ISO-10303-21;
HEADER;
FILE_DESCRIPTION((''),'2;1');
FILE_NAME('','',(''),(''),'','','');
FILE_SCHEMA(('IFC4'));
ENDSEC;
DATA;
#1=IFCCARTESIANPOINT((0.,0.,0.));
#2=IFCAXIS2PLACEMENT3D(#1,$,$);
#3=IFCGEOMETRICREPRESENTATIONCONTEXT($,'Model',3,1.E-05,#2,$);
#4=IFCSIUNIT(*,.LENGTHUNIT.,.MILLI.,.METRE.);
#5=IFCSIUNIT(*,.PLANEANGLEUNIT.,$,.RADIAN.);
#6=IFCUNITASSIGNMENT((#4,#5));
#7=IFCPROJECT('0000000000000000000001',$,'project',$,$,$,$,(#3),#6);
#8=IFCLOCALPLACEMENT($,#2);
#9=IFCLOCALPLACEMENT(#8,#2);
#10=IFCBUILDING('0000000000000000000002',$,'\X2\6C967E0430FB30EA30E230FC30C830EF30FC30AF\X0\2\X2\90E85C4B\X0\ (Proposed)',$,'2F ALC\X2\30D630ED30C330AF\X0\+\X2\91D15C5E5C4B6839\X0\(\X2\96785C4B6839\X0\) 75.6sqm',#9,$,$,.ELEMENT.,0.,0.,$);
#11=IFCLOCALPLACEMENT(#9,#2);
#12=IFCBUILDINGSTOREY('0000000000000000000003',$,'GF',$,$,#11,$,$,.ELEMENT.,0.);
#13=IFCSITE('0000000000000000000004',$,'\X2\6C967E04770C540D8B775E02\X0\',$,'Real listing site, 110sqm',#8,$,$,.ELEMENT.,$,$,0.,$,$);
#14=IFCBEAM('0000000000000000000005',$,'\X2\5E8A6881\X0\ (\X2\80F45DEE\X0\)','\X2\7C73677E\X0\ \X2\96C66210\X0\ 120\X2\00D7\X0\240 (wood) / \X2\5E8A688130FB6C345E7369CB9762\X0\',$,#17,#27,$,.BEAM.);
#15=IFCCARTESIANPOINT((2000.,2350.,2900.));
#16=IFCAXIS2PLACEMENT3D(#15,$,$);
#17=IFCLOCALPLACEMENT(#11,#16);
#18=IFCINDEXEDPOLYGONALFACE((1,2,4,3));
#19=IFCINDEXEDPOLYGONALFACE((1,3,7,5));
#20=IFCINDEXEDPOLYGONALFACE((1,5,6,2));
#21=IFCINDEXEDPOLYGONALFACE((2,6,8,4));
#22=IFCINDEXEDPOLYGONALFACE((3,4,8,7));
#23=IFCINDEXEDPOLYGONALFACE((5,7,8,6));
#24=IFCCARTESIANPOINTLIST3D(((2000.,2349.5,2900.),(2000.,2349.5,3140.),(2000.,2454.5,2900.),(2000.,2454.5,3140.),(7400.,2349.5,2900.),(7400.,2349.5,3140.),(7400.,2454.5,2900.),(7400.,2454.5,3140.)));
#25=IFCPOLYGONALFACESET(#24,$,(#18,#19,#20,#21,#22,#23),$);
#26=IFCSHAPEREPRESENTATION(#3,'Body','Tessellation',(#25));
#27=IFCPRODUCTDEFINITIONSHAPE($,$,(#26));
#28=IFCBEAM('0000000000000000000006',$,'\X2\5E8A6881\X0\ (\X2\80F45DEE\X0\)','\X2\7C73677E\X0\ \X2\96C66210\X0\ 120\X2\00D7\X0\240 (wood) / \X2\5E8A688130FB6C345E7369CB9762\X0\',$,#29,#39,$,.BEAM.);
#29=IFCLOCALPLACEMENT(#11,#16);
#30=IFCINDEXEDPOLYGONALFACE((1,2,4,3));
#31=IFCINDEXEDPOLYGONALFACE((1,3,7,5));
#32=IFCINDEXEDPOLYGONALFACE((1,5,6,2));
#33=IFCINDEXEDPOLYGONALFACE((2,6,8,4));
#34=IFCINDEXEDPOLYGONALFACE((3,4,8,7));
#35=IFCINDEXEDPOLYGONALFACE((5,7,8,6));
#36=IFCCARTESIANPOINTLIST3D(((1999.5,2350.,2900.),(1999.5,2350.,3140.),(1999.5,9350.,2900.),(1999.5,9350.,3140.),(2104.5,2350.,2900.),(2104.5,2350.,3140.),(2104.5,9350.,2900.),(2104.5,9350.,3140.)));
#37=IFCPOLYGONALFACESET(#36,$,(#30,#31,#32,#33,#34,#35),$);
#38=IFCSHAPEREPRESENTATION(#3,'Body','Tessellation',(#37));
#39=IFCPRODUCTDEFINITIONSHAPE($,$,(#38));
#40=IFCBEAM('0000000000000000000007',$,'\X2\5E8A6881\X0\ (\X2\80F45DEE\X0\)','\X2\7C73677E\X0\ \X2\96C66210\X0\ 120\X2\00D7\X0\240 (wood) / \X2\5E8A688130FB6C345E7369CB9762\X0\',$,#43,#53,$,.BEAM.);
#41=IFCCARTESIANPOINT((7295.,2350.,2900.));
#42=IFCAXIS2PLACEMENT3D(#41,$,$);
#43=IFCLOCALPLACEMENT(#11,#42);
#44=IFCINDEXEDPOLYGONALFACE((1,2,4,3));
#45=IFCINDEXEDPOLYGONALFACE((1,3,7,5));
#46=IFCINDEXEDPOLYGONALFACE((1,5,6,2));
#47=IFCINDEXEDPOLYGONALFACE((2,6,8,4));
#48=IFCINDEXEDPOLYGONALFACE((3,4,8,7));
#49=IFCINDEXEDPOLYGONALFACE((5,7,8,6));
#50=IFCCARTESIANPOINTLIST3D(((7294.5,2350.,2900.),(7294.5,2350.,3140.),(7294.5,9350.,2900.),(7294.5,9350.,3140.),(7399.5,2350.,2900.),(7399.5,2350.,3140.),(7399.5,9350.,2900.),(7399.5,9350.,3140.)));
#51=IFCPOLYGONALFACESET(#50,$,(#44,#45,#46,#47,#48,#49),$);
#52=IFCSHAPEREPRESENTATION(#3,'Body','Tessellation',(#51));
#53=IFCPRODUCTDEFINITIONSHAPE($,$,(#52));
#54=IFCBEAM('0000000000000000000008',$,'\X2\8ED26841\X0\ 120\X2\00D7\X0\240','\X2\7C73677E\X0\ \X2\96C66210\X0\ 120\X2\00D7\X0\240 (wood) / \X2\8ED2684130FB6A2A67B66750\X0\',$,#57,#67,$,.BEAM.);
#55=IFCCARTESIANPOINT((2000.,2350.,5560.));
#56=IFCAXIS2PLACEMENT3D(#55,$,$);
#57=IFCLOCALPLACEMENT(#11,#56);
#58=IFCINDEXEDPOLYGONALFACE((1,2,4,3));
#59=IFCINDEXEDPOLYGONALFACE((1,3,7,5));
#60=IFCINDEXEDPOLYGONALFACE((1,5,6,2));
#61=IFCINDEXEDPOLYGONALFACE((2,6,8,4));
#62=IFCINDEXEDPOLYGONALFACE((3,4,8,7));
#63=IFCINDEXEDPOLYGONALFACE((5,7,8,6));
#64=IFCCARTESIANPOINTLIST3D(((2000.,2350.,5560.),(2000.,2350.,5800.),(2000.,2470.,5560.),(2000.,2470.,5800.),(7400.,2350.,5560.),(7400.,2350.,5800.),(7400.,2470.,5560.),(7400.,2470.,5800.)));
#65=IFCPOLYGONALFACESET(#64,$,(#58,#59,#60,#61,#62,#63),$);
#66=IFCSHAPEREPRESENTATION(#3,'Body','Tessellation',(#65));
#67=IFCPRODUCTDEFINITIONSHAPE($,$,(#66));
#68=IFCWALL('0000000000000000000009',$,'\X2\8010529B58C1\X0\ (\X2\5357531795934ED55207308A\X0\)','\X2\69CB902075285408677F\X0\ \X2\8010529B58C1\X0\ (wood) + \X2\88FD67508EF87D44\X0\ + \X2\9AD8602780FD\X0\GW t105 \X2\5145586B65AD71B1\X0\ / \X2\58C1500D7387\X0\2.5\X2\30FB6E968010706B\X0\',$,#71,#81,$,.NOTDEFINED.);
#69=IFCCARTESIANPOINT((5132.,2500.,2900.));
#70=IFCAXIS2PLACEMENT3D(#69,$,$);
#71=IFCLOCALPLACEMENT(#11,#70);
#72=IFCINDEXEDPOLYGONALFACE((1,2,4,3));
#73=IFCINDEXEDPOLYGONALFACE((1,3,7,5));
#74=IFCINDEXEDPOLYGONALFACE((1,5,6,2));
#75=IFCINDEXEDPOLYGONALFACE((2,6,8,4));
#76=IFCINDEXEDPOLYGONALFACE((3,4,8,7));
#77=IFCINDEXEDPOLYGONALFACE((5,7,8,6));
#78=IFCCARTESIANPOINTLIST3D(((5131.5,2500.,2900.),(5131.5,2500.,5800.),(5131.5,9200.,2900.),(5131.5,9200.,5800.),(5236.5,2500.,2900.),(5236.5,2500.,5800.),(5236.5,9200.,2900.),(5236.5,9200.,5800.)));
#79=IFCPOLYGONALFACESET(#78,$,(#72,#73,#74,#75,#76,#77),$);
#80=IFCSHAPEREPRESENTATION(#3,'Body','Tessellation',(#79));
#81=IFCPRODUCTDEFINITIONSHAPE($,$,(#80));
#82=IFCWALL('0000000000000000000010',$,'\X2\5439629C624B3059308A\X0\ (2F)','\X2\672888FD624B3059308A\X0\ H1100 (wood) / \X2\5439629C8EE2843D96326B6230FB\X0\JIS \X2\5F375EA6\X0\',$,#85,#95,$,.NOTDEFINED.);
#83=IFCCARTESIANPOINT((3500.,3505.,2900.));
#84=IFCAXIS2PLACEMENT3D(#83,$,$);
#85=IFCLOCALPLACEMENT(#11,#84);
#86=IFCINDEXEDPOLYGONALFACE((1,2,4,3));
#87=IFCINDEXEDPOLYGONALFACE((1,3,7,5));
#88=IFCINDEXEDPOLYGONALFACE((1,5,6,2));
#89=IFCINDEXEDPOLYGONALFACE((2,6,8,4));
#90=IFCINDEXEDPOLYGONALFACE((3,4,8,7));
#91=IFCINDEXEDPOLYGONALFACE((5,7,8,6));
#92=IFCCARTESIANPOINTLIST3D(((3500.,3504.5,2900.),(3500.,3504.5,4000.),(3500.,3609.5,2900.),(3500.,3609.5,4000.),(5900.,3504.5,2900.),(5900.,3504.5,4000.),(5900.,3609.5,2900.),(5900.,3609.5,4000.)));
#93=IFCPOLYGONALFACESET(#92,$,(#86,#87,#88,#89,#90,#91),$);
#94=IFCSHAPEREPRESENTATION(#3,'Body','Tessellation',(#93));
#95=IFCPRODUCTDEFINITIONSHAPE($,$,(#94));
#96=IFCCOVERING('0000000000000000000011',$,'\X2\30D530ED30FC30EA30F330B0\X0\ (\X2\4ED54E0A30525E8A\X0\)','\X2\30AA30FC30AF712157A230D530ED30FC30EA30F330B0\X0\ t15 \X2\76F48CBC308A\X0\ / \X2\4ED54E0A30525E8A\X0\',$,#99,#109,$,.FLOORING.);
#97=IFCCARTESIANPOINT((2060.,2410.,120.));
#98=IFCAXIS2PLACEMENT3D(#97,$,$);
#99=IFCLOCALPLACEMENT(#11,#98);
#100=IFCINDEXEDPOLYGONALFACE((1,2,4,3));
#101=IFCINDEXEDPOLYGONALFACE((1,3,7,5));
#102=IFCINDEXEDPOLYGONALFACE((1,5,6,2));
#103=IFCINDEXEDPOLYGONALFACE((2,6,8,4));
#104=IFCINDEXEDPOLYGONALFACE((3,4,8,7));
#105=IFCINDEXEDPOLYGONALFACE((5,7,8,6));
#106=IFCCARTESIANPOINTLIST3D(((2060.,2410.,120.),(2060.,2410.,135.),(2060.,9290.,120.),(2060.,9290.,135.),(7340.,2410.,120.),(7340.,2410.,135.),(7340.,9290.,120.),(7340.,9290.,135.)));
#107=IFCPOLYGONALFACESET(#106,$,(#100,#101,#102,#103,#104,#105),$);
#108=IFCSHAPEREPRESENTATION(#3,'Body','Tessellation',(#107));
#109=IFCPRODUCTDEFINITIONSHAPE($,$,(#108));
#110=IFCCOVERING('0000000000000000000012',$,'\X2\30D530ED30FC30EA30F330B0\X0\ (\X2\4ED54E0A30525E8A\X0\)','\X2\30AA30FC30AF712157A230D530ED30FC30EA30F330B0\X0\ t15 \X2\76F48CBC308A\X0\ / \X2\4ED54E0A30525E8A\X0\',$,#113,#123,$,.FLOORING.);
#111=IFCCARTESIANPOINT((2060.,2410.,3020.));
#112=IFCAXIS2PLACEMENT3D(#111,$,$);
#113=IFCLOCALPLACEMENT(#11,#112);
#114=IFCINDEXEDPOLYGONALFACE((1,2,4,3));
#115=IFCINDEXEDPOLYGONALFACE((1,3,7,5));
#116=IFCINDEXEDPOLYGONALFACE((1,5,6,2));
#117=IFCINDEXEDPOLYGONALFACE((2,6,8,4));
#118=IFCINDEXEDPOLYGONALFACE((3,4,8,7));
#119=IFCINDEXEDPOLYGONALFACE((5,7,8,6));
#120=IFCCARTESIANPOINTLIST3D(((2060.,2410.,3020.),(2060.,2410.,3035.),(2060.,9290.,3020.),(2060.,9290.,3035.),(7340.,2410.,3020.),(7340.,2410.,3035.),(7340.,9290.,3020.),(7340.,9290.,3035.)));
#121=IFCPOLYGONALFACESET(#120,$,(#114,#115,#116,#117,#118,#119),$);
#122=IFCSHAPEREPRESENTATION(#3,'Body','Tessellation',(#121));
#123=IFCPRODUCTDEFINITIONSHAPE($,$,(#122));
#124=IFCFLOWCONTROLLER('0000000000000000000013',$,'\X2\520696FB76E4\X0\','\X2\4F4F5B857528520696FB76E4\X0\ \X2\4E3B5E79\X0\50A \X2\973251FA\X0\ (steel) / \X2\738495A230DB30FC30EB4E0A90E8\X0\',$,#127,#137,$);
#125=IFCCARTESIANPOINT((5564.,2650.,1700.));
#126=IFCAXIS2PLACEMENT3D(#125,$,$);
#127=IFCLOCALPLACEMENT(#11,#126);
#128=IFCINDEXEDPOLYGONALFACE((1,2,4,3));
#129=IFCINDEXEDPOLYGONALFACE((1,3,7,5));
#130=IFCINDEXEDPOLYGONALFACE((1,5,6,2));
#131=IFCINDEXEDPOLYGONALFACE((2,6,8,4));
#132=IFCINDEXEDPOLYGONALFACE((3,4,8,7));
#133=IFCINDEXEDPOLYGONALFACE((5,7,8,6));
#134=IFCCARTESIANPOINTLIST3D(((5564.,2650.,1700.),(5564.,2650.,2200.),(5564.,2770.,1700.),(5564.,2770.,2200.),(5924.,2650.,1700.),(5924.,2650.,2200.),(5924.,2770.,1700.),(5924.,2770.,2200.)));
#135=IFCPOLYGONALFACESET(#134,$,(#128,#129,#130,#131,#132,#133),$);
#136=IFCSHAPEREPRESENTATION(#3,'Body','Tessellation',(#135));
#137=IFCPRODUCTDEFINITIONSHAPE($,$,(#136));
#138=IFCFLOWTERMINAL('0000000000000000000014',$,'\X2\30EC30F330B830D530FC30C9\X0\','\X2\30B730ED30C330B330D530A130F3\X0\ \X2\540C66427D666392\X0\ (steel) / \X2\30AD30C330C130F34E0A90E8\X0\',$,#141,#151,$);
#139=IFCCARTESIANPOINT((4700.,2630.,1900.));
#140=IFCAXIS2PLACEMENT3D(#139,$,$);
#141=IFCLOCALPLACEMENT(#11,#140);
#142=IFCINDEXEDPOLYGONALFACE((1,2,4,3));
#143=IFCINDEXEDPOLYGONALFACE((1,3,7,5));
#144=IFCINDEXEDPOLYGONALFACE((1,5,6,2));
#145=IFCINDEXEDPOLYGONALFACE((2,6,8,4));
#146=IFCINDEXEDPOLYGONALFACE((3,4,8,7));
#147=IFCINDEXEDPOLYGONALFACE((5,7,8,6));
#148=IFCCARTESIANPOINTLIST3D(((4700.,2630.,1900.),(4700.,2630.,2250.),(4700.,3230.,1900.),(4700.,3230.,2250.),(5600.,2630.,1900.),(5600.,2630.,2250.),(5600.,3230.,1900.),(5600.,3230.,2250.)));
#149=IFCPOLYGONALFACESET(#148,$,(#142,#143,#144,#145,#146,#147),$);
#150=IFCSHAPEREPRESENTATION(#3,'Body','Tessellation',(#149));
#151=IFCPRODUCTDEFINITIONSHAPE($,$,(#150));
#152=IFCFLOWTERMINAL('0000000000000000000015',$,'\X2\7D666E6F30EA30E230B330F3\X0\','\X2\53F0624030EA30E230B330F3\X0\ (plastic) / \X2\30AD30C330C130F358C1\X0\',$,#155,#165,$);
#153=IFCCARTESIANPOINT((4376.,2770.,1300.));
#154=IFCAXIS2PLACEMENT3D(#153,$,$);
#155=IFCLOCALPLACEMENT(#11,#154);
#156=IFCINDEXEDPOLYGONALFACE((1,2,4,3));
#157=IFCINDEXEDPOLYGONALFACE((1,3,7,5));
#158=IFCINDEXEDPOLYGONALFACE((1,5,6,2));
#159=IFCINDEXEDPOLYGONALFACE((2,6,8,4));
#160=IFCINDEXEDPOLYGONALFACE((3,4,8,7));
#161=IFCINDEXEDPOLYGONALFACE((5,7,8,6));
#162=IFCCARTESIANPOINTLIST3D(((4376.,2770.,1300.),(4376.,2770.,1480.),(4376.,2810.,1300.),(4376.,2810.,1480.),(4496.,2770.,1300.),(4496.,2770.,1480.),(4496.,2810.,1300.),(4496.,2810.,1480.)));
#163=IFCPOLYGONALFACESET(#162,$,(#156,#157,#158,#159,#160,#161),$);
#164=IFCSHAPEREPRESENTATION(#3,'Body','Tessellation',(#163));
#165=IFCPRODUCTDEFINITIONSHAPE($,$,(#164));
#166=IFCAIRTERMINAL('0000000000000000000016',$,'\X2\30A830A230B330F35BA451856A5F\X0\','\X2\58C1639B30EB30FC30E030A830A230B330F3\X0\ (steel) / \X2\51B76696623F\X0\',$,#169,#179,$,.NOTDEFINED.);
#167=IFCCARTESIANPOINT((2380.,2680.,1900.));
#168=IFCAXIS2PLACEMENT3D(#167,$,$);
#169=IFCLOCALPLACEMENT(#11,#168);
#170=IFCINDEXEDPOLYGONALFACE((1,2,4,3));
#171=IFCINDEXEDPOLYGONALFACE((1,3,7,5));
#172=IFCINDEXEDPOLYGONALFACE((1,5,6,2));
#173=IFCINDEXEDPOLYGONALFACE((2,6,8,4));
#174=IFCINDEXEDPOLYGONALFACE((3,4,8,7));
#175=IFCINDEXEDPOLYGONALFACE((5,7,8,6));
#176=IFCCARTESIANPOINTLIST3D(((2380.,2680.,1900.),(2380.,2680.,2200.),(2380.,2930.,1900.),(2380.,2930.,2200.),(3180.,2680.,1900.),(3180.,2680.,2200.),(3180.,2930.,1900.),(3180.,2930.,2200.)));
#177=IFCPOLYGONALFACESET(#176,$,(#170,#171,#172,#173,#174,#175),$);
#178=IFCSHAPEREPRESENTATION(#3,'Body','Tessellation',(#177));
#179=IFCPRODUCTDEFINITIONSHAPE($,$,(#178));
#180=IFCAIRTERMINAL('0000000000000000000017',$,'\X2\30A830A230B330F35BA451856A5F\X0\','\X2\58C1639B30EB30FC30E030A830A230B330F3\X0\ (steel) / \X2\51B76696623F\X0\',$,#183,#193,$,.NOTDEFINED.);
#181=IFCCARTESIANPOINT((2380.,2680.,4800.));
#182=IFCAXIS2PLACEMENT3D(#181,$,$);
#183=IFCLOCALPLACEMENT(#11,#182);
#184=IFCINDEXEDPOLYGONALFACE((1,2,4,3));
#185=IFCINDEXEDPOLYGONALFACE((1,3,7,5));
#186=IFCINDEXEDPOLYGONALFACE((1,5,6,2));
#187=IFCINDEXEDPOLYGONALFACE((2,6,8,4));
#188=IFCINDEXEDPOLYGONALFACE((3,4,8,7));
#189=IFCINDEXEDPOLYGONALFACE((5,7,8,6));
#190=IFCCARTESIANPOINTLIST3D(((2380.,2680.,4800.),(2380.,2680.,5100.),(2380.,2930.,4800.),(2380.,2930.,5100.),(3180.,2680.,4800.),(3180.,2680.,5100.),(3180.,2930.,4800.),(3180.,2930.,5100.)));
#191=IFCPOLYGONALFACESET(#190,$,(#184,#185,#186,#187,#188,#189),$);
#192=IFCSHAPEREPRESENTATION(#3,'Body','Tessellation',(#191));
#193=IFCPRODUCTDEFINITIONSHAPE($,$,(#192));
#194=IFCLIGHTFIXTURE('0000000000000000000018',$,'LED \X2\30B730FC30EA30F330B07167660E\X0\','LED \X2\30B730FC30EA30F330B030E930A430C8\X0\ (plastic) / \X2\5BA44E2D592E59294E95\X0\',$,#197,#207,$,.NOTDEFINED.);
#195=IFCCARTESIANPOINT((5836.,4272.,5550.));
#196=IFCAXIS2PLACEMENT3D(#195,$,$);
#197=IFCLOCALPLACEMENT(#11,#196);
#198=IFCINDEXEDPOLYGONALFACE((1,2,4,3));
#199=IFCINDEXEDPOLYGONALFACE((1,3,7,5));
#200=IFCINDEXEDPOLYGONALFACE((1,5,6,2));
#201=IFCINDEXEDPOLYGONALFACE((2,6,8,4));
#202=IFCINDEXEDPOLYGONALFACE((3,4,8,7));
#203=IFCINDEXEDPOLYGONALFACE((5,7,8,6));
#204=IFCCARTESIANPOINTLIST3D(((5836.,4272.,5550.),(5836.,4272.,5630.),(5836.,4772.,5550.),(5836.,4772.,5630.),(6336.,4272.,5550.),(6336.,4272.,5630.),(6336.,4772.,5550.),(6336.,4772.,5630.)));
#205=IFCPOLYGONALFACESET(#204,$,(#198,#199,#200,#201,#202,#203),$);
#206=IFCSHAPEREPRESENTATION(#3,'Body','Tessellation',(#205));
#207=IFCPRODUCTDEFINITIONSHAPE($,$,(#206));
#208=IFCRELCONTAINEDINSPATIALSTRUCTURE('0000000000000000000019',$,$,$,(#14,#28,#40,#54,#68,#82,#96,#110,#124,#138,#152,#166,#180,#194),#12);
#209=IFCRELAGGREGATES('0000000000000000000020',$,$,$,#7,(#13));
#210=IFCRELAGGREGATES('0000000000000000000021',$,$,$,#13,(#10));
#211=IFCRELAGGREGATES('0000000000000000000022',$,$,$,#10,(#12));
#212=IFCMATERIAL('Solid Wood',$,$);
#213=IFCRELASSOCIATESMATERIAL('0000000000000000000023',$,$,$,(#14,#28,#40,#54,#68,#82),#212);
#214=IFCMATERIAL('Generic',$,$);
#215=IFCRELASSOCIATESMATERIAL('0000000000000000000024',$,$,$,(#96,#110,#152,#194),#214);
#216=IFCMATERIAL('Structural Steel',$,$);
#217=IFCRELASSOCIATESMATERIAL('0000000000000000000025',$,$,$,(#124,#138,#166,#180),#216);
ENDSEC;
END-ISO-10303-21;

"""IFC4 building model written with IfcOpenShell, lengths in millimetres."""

from ifc_helpers import new_model, si_unit, frame, frame_2d, origin, place, context, project, spatial, rectangle, extrude, material, element, save


model = new_model("IFC4")

# Units and contexts
model_context = context("Model", 3, precision=1e-05, world=origin())
ifc_project = project(units=[si_unit("LENGTHUNIT", "METRE", prefix="MILLI"), si_unit("PLANEANGLEUNIT", "RADIAN")], contexts=[model_context])

# Site, building, storey
site_placement = place(None, origin())
site = spatial("IfcSite", under=ifc_project, at=site_placement, Name="沖縄県名護市", ObjectType="Real listing site, 110sqm", CompositionType="ELEMENT", RefElevation=0.0)
building_placement = place(site_placement, origin())
building = spatial("IfcBuilding", under=site, at=building_placement, Name="沖縄・リモートワーク2部屋 (Proposed)", ObjectType="2F ALCブロック+金属屋根(陸屋根) 75.6sqm", CompositionType="ELEMENT", ElevationOfRefHeight=0.0, ElevationOfTerrain=0.0)
storey_placement = place(building_placement, origin())
storey = spatial("IfcBuildingStorey", under=building, at=storey_placement, Name="GF", CompositionType="ELEMENT", Elevation=0.0)

# Shared definitions
ifc_material_1 = material(Name="Solid Wood")

# Beams
beam_1_placement = place(storey_placement, frame((2000.0, 2350.0, 2900.0)))
element("IfcBeam", 1, at=beam_1_placement, inside=storey, material=ifc_material_1, Name="床梁 (胴差)", Description="米松 集成 120×240 (wood) / 床梁・水平構面", PredefinedType="BEAM", context=model_context, shape_type="SweptSolid", body=[
    extrude(rectangle(XDim=5400.0, YDim=105.0, at=frame_2d((2700.0, 52.0))), frame((2000.0, 2350.0, 2900.0)), (0.0, 0.0, 1.0), 240.0),
])
beam_2_placement = place(storey_placement, frame((2000.0, 2350.0, 2900.0)))
element("IfcBeam", 2, at=beam_2_placement, inside=storey, material=ifc_material_1, Name="床梁 (胴差)", Description="米松 集成 120×240 (wood) / 床梁・水平構面", PredefinedType="BEAM", context=model_context, shape_type="SweptSolid", body=[
    extrude(rectangle(XDim=105.0, YDim=7000.0, at=frame_2d((52.0, 3500.0))), frame((2000.0, 2350.0, 2900.0)), (0.0, 0.0, 1.0), 240.0),
])
beam_3_placement = place(storey_placement, frame((7295.0, 2350.0, 2900.0)))
element("IfcBeam", 3, at=beam_3_placement, inside=storey, material=ifc_material_1, Name="床梁 (胴差)", Description="米松 集成 120×240 (wood) / 床梁・水平構面", PredefinedType="BEAM", context=model_context, shape_type="SweptSolid", body=[
    extrude(rectangle(XDim=105.0, YDim=7000.0, at=frame_2d((52.0, 3500.0))), frame((7295.0, 2350.0, 2900.0)), (0.0, 0.0, 1.0), 240.0),
])
beam_4_placement = place(storey_placement, frame((2000.0, 2350.0, 5560.0)))
element("IfcBeam", 4, at=beam_4_placement, inside=storey, material=ifc_material_1, Name="軒桁 120×240", Description="米松 集成 120×240 (wood) / 軒桁・横架材", PredefinedType="BEAM", context=model_context, shape_type="SweptSolid", body=[
    extrude(rectangle(XDim=5400.0, YDim=120.0, at=frame_2d((2700.0, 60.0))), frame((2000.0, 2350.0, 5560.0)), (0.0, 0.0, 1.0), 240.0),
])

# Walls
wall_1_placement = place(storey_placement, frame((5132.0, 2500.0, 2900.0)))
element("IfcWall", 5, at=wall_1_placement, inside=storey, material=ifc_material_1, Name="耐力壁 (南北間仕切り)", Description="構造用合板 耐力壁 (wood) + 製材軸組 + 高性能GW t105 充填断熱 / 壁倍率2.5・準耐火", PredefinedType="NOTDEFINED", context=model_context, shape_type="SweptSolid", body=[
    extrude(rectangle(XDim=105.0, YDim=6700.0, at=frame_2d((52.0, 3350.0))), frame((5132.0, 2500.0, 2900.0)), (0.0, 0.0, 1.0), 2900.0),
])
wall_2_placement = place(storey_placement, frame((3500.0, 3505.0, 2900.0)))
element("IfcWall", 6, at=wall_2_placement, inside=storey, material=ifc_material_1, Name="吹抜手すり (2F)", Description="木製手すり H1100 (wood) / 吹抜転落防止・JIS 強度", PredefinedType="NOTDEFINED", context=model_context, shape_type="SweptSolid", body=[
    extrude(rectangle(XDim=2400.0, YDim=105.0, at=frame_2d((1200.0, 52.0))), frame((3500.0, 3505.0, 2900.0)), (0.0, 0.0, 1.0), 1100.0),
])

# Coverings
ifc_material_2 = material(Name="Generic")
covering_1_placement = place(storey_placement, frame((2060.0, 2410.0, 120.0)))
element("IfcCovering", 7, at=covering_1_placement, inside=storey, material=ifc_material_2, Name="フローリング (仕上げ床)", Description="オーク無垢フローリング t15 直貼り / 仕上げ床", PredefinedType="FLOORING", context=model_context, shape_type="SweptSolid", body=[
    extrude(rectangle(XDim=5280.0, YDim=6880.0, at=frame_2d((2640.0, 3440.0))), frame((2060.0, 2410.0, 120.0)), (0.0, 0.0, 1.0), 15.0),
])
covering_2_placement = place(storey_placement, frame((2060.0, 2410.0, 3020.0)))
element("IfcCovering", 8, at=covering_2_placement, inside=storey, material=ifc_material_2, Name="フローリング (仕上げ床)", Description="オーク無垢フローリング t15 直貼り / 仕上げ床", PredefinedType="FLOORING", context=model_context, shape_type="SweptSolid", body=[
    extrude(rectangle(XDim=5280.0, YDim=6880.0, at=frame_2d((2640.0, 3440.0))), frame((2060.0, 2410.0, 3020.0)), (0.0, 0.0, 1.0), 15.0),
])

# Flow controller
ifc_material_3 = material(Name="Structural Steel")
flow_controller_placement = place(storey_placement, frame((5564.0, 2650.0, 1700.0)))
element("IfcFlowController", 9, at=flow_controller_placement, inside=storey, material=ifc_material_3, Name="分電盤", Description="住宅用分電盤 主幹50A 露出 (steel) / 玄関ホール上部", context=model_context, shape_type="SweptSolid", body=[
    extrude(rectangle(XDim=360.0, YDim=120.0, at=frame_2d((180.0, 60.0))), frame((5564.0, 2650.0, 1700.0)), (0.0, 0.0, 1.0), 500.0),
])

# Flow terminals
flow_terminal_1_placement = place(storey_placement, frame((4700.0, 2630.0, 1900.0)))
element("IfcFlowTerminal", 10, at=flow_terminal_1_placement, inside=storey, material=ifc_material_3, Name="レンジフード", Description="シロッコファン 同時給排 (steel) / キッチン上部", context=model_context, shape_type="SweptSolid", body=[
    extrude(rectangle(XDim=900.0, YDim=600.0, at=frame_2d((450.0, 300.0))), frame((4700.0, 2630.0, 1900.0)), (0.0, 0.0, 1.0), 350.0),
])
flow_terminal_2_placement = place(storey_placement, frame((4376.0, 2770.0, 1300.0)))
element("IfcFlowTerminal", 11, at=flow_terminal_2_placement, inside=storey, material=ifc_material_2, Name="給湯リモコン", Description="台所リモコン (plastic) / キッチン壁", context=model_context, shape_type="SweptSolid", body=[
    extrude(rectangle(XDim=120.0, YDim=40.0, at=frame_2d((60.0, 20.0))), frame((4376.0, 2770.0, 1300.0)), (0.0, 0.0, 1.0), 180.0),
])

# Air terminals
air_terminal_1_placement = place(storey_placement, frame((2380.0, 2680.0, 1900.0)))
element("IfcAirTerminal", 12, at=air_terminal_1_placement, inside=storey, material=ifc_material_3, Name="エアコン室内機", Description="壁掛ルームエアコン (steel) / 冷暖房", PredefinedType="NOTDEFINED", context=model_context, shape_type="SweptSolid", body=[
    extrude(rectangle(XDim=800.0, YDim=250.0, at=frame_2d((400.0, 125.0))), frame((2380.0, 2680.0, 1900.0)), (0.0, 0.0, 1.0), 300.0),
])
air_terminal_2_placement = place(storey_placement, frame((2380.0, 2680.0, 4800.0)))
element("IfcAirTerminal", 13, at=air_terminal_2_placement, inside=storey, material=ifc_material_3, Name="エアコン室内機", Description="壁掛ルームエアコン (steel) / 冷暖房", PredefinedType="NOTDEFINED", context=model_context, shape_type="SweptSolid", body=[
    extrude(rectangle(XDim=800.0, YDim=250.0, at=frame_2d((400.0, 125.0))), frame((2380.0, 2680.0, 4800.0)), (0.0, 0.0, 1.0), 300.0),
])

# Light fixture
light_fixture_placement = place(storey_placement, frame((5836.0, 4272.0, 5550.0)))
element("IfcLightFixture", 14, at=light_fixture_placement, inside=storey, material=ifc_material_2, Name="LED シーリング照明", Description="LED シーリングライト (plastic) / 室中央天井", PredefinedType="NOTDEFINED", context=model_context, shape_type="SweptSolid", body=[
    extrude(rectangle(XDim=500.0, YDim=500.0, at=frame_2d((250.0, 250.0))), frame((5836.0, 4272.0, 5550.0)), (0.0, 0.0, 1.0), 80.0),
])

save(model, "model.ifc")
